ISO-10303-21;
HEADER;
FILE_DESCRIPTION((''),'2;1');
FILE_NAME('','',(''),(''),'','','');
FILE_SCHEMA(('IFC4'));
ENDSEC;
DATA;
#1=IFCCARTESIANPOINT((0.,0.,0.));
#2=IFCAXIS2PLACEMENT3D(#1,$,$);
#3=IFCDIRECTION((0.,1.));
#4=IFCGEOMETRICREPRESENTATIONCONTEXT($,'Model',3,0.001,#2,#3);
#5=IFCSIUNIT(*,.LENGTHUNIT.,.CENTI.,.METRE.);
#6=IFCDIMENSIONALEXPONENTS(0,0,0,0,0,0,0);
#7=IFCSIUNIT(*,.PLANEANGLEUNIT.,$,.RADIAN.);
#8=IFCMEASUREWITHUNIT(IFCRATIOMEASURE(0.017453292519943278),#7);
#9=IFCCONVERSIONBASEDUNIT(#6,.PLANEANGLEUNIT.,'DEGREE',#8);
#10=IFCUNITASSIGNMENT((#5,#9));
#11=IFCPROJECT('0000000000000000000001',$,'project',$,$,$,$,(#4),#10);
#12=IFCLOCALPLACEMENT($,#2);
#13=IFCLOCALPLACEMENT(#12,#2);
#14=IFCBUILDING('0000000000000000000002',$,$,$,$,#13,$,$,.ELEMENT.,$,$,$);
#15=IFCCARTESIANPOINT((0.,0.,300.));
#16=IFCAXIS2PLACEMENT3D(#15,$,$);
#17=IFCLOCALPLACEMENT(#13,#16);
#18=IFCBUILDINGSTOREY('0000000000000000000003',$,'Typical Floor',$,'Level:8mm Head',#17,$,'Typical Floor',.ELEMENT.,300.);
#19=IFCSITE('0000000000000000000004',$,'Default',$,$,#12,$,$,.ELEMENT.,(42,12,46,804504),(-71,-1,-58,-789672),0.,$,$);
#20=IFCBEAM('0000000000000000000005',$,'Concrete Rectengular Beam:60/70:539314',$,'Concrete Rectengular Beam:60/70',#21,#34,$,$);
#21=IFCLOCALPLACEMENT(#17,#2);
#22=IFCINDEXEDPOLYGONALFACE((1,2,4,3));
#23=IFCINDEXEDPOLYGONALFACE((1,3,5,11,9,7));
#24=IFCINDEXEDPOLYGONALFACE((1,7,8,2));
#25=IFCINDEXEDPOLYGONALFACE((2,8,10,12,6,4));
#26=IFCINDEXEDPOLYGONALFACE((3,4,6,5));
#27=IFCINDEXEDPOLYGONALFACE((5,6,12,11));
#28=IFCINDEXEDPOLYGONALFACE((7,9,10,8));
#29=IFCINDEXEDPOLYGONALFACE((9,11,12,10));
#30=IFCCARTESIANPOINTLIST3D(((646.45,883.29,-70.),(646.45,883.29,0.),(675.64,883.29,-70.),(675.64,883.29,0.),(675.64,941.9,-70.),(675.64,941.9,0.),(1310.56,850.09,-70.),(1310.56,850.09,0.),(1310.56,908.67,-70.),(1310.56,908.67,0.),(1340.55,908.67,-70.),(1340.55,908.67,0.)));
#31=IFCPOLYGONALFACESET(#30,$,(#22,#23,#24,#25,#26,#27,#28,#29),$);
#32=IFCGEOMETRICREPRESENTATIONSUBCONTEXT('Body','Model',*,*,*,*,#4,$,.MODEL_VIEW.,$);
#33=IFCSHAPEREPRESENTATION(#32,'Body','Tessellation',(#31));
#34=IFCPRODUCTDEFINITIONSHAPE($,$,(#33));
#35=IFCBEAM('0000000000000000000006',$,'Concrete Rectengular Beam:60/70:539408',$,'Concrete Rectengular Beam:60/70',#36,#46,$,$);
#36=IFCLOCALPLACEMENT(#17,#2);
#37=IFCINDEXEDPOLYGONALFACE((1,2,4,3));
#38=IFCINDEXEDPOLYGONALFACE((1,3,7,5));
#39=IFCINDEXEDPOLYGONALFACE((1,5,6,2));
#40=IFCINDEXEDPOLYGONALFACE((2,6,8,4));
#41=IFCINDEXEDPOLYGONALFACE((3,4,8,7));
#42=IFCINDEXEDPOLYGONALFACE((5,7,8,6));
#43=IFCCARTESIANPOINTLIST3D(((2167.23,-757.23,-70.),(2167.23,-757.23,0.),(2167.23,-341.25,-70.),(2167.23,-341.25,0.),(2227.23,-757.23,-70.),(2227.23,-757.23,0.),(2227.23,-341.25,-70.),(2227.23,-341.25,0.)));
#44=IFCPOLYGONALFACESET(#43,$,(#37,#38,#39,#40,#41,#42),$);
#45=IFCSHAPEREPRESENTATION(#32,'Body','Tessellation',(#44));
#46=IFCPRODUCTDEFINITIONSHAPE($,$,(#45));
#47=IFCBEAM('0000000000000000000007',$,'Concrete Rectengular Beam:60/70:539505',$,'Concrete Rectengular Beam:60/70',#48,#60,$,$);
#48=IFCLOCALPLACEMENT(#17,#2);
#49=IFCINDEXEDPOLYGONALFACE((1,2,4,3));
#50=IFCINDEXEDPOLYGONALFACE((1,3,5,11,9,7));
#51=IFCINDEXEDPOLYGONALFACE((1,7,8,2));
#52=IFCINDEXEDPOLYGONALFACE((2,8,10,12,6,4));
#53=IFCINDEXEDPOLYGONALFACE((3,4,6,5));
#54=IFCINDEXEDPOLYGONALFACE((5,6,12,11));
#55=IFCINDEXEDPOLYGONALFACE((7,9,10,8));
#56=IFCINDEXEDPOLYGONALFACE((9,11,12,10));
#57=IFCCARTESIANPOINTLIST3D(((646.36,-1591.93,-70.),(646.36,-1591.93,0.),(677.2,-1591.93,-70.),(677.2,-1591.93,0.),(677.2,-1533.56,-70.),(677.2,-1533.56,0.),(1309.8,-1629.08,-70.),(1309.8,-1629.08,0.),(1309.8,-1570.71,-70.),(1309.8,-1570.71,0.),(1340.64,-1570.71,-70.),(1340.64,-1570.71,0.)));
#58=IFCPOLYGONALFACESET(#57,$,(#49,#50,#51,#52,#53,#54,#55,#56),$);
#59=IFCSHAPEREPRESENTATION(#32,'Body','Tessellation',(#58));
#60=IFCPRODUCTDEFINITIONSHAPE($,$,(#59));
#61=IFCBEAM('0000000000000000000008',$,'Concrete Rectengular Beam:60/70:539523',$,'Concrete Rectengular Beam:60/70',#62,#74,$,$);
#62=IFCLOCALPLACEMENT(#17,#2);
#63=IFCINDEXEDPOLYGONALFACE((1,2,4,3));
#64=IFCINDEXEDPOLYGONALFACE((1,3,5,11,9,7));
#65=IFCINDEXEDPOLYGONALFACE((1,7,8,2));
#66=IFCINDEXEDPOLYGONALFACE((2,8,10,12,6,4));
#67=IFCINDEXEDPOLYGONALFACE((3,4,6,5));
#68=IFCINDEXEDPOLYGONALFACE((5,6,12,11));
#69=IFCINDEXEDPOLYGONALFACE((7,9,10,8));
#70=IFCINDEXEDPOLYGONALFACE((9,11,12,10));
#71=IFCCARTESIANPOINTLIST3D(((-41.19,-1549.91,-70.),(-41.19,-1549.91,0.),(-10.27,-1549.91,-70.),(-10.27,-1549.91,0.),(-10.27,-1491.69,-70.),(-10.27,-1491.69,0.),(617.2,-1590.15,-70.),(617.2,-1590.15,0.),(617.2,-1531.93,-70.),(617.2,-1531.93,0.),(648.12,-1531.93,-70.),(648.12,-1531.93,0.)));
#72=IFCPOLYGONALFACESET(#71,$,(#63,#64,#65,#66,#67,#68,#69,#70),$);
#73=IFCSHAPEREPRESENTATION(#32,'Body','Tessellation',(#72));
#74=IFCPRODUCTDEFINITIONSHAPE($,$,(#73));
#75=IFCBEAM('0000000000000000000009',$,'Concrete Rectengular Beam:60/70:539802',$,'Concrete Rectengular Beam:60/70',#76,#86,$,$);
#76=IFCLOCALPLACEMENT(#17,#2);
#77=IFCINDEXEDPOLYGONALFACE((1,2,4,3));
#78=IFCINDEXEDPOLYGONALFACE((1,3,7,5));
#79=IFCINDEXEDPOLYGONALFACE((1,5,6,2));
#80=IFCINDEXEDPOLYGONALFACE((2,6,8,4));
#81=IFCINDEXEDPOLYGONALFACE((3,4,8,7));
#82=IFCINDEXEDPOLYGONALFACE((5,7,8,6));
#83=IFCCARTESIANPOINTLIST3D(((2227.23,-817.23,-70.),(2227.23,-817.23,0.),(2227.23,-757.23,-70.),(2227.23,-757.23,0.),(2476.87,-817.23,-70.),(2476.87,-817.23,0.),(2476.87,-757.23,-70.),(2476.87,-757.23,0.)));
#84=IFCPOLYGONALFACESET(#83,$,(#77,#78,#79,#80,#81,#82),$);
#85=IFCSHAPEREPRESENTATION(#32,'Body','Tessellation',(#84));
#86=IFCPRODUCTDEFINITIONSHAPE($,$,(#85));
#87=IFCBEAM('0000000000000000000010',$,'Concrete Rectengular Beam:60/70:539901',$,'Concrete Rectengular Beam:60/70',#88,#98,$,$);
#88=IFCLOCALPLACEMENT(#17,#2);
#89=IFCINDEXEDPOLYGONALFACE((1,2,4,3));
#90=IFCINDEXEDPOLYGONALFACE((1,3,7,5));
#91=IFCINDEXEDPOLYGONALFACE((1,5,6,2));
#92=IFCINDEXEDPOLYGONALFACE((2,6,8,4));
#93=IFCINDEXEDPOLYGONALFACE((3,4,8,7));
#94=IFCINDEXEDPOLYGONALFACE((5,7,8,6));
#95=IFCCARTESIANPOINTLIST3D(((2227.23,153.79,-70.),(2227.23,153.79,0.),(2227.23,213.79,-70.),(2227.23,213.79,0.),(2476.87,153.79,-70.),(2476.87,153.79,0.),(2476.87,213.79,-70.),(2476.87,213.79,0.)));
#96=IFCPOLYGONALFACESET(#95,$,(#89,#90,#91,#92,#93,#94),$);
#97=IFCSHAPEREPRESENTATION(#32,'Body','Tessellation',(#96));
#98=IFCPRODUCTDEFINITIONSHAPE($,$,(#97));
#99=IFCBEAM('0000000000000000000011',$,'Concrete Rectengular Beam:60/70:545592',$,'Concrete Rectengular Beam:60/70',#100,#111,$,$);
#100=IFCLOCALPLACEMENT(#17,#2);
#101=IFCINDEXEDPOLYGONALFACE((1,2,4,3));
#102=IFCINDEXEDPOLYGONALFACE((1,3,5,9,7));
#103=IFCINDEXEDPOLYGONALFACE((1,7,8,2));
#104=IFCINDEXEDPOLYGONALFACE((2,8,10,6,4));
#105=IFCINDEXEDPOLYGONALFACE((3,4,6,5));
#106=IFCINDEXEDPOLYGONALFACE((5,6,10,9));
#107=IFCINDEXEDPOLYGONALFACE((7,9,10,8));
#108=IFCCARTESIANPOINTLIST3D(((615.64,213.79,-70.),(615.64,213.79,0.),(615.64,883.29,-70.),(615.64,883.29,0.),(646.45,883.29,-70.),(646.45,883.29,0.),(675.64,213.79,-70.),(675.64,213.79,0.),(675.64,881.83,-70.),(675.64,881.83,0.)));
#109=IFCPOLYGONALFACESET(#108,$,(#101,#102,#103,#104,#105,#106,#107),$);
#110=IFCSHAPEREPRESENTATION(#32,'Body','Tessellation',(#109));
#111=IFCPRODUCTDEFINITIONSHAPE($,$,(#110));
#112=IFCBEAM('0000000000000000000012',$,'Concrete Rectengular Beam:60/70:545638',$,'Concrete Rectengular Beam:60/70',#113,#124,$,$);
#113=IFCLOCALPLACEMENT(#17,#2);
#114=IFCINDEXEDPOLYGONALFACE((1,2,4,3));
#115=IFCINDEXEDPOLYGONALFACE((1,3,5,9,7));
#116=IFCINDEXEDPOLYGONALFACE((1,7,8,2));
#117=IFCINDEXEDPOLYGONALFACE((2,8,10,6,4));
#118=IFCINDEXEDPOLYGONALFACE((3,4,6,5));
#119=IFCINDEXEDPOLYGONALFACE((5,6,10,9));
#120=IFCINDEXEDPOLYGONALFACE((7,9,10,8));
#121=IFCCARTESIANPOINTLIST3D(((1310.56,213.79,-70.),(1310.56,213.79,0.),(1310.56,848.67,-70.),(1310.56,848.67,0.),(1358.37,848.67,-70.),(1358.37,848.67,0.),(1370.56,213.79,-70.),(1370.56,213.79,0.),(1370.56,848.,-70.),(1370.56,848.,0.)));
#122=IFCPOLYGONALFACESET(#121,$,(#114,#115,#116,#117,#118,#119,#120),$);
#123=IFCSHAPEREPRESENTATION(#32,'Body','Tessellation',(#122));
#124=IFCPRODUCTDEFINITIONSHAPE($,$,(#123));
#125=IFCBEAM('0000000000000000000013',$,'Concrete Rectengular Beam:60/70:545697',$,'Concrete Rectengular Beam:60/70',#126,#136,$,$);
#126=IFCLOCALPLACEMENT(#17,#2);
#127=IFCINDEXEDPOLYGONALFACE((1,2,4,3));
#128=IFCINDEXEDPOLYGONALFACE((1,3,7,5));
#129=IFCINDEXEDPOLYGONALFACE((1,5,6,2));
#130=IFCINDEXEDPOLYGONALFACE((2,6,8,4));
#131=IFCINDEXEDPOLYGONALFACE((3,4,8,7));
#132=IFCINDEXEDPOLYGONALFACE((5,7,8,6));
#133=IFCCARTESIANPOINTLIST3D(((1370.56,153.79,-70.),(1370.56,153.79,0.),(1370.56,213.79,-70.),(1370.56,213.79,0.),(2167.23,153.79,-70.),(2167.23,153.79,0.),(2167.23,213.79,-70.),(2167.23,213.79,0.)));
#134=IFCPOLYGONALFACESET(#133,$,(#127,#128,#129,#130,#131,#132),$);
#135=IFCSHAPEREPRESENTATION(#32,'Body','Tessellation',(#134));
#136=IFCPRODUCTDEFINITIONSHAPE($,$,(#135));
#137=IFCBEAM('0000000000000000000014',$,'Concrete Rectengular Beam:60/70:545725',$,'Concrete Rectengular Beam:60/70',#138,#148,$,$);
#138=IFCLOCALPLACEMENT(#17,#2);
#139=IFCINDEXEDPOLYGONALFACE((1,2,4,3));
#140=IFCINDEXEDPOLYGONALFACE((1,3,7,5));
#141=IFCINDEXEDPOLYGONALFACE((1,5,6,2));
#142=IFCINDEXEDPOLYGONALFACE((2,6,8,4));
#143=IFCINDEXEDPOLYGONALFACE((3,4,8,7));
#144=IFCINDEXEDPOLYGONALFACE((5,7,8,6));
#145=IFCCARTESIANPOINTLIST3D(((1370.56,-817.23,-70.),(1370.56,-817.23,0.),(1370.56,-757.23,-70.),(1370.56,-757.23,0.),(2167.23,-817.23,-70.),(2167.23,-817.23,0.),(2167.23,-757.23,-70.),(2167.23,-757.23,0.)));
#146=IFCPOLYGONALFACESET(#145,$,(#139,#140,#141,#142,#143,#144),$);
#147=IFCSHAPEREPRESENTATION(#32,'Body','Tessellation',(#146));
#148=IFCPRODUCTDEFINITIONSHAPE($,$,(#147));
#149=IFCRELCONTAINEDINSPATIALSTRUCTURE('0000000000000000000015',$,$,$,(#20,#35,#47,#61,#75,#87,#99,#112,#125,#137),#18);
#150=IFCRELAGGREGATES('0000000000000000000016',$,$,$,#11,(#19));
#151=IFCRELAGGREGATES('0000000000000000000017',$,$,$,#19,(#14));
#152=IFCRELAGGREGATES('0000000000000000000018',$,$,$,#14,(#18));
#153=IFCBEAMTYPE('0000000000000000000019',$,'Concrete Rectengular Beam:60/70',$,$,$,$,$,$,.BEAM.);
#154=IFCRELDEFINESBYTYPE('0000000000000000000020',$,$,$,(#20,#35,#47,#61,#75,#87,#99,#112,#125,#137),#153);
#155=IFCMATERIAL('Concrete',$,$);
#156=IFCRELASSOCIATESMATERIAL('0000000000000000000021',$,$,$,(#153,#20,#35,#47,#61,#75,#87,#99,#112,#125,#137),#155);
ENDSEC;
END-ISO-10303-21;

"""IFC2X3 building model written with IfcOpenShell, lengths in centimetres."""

from ifc_helpers import new_model, entity, si_unit, converted_unit, direction, frame, frame_2d, origin, origin_2d_with_axis, place, context, subcontext, project, spatial, polyline, rectangle, extrude, clip, halfspace, bounded_halfspace, material, type_object, element, save


model = new_model("IFC2X3")

# Units and contexts
model_context = context("Model", 3, precision=0.001, world=origin(), true_north=direction((0.0, 1.0)))
body_context = subcontext(model_context, "Body", "Model", "MODEL_VIEW")
ifc_project = project(units=[si_unit("LENGTHUNIT", "METRE", prefix="CENTI"), converted_unit("PLANEANGLEUNIT", "DEGREE", entity("IfcRatioMeasure", 0.017453292519943278), si_unit("PLANEANGLEUNIT", "RADIAN"), dimensions=[0, 0, 0, 0, 0, 0, 0])], contexts=[model_context])

# Site, building, storey
site_placement = place(None, origin())
site = spatial("IfcSite", under=ifc_project, at=site_placement, Name="Default", CompositionType="ELEMENT", RefLatitude=(42, 12, 46, 804504), RefLongitude=(-71, -1, -58, -789672), RefElevation=0.0)
building_placement = place(site_placement, origin())
building = spatial("IfcBuilding", under=site, at=building_placement, CompositionType="ELEMENT")
storey_placement = place(building_placement, frame((0.0, 0.0, 300.0)))
storey = spatial("IfcBuildingStorey", under=building, at=storey_placement, Name="Typical Floor", ObjectType="Level:8mm Head", LongName="Typical Floor", CompositionType="ELEMENT", Elevation=300.0)

# Beams
ifc_material = material(Name="Concrete")
beam_type = type_object("IfcBeamType", Name="Concrete Rectengular Beam:60/70", PredefinedType="BEAM", material=ifc_material)
beam_1_placement = place(storey_placement, frame((647.2, 913.29, 0.0), z_axis=(0.0, 0.0, 1.0), x_axis=(0.998753, -0.049923, 0.0)))
element("IfcBeam", 1, at=beam_1_placement, inside=storey, type_object=beam_type, material=ifc_material, Name="Concrete Rectengular Beam:60/70:539314", ObjectType="Concrete Rectengular Beam:60/70", context=body_context, shape_type="SweptSolid", body=[
    clip(clip(clip(clip(extrude(rectangle(XDim=70.0, YDim=60.0, at=frame_2d((0.0, 0.0), x_axis=(1.0, 0.0))), frame((0.75, 0.0, -35.0), z_axis=(1.0, 0.0, 0.0), x_axis=(0.0, 0.0, -1.0)), (0.0, 0.0, 1.0), 691.97), bounded_halfspace(frame((29.9, -28.54, 0.0), z_axis=(-0.998753, -0.049923, 0.0), x_axis=(0.0, 0.0, -1.0)), False, frame((0.75, 0.0, -35.0), z_axis=(1.0, 0.0, 0.0), x_axis=(0.0, 0.0, -1.0)), polyline([(35.0, -28.54), (-35.0, -28.54), (-35.0, 30.0), (35.0, 30.0), (35.0, -28.54)]))), bounded_halfspace(frame((-30.02, -31.54, 0.0), z_axis=(-0.049923, 0.998753, 0.0), x_axis=(0.0, 0.0, -1.0)), False, frame((0.75, 0.0, -35.0), z_axis=(1.0, 0.0, 0.0), x_axis=(0.0, 0.0, -1.0)), polyline([(-35.0, -28.54), (35.0, -28.54), (35.0, -30.0), (-35.0, -30.0), (-35.0, -28.54)]))), bounded_halfspace(frame((722.68, 31.5, 0.0), z_axis=(0.049923, -0.998753, 0.0), x_axis=(0.0, 0.0, -1.0)), False, frame((0.75, 0.0, -35.0), z_axis=(1.0, 0.0, 0.0), x_axis=(0.0, 0.0, -1.0)), polyline([(-35.0, 28.5), (35.0, 28.5), (35.0, 30.0), (-35.0, 30.0), (-35.0, 28.5)]))), bounded_halfspace(frame((662.76, 28.5, 0.0), z_axis=(0.998753, 0.049923, 0.0), x_axis=(0.0, 0.0, -1.0)), False, frame((0.75, 0.0, -35.0), z_axis=(1.0, 0.0, 0.0), x_axis=(0.0, 0.0, -1.0)), polyline([(35.0, 28.5), (-35.0, 28.5), (-35.0, -30.0), (-15.0, -30.0), (35.0, -30.0), (35.0, 28.5)]))),
])
beam_2_placement = place(storey_placement, frame((2197.23, -311.25, 0.0), z_axis=(0.0, 0.0, 1.0), x_axis=(0.0, -1.0, 0.0)))
element("IfcBeam", 2, at=beam_2_placement, inside=storey, type_object=beam_type, material=ifc_material, Name="Concrete Rectengular Beam:60/70:539408", ObjectType="Concrete Rectengular Beam:60/70", context=body_context, shape_type="SweptSolid", body=[
    extrude(rectangle(XDim=70.0, YDim=60.0, at=origin_2d_with_axis()), frame((30.0, 0.0, -35.0), z_axis=(1.0, 0.0, 0.0), x_axis=(0.0, 0.0, -1.0)), (0.0, 0.0, 1.0), 415.98),
])
beam_3_placement = place(storey_placement, frame((1339.8, -1600.71, 0.0), z_axis=(0.0, 0.0, 1.0), x_axis=(-0.998436, 0.055911, 0.0)))
element("IfcBeam", 3, at=beam_3_placement, inside=storey, type_object=beam_type, material=ifc_material, Name="Concrete Rectengular Beam:60/70:539505", ObjectType="Concrete Rectengular Beam:60/70", context=body_context, shape_type="SweptSolid", body=[
    clip(clip(clip(clip(extrude(rectangle(XDim=70.0, YDim=60.0, at=frame_2d((0.0, 0.0), x_axis=(1.0, 0.0))), frame((0.84, 0.0, -35.0), z_axis=(1.0, 0.0, 0.0), x_axis=(0.0, 0.0, -1.0)), (0.0, 0.0, 1.0), 692.01), bounded_halfspace(frame((662.06, 28.28, 0.0), z_axis=(0.998436, 0.055911, 0.0), x_axis=(0.0, 0.0, -1.0)), False, frame((0.84, 0.0, -35.0), z_axis=(1.0, 0.0, 0.0), x_axis=(0.0, 0.0, -1.0)), polyline([(35.0, 28.28), (-35.0, 28.28), (-35.0, -30.0), (-10.0, -30.0), (35.0, -30.0), (35.0, 28.28)]))), bounded_halfspace(frame((721.96, 31.63, 0.0), z_axis=(0.055911, -0.998436, 0.0), x_axis=(0.0, 0.0, -1.0)), False, frame((0.84, 0.0, -35.0), z_axis=(1.0, 0.0, 0.0), x_axis=(0.0, 0.0, -1.0)), polyline([(-35.0, 28.28), (35.0, 28.28), (35.0, 30.0), (-35.0, 30.0), (-35.0, 28.28)]))), bounded_halfspace(frame((-28.28, -31.63, 0.0), z_axis=(-0.055911, 0.998436, 0.0), x_axis=(0.0, 0.0, -1.0)), False, frame((0.84, 0.0, -35.0), z_axis=(1.0, 0.0, 0.0), x_axis=(0.0, 0.0, -1.0)), polyline([(-35.0, -28.28), (35.0, -28.28), (35.0, -30.0), (-35.0, -30.0), (-35.0, -28.28)]))), bounded_halfspace(frame((31.63, -28.28, 0.0), z_axis=(-0.998436, -0.055911, 0.0), x_axis=(0.0, 0.0, -1.0)), False, frame((0.84, 0.0, -35.0), z_axis=(1.0, 0.0, 0.0), x_axis=(0.0, 0.0, -1.0)), polyline([(35.0, -28.28), (-35.0, -28.28), (-35.0, 30.0), (35.0, 30.0), (35.0, -28.28)]))),
])
beam_4_placement = place(storey_placement, frame((647.2, -1561.93, 0.0), z_axis=(0.0, 0.0, 1.0), x_axis=(-0.998138, 0.061004, 0.0)))
element("IfcBeam", 4, at=beam_4_placement, inside=storey, type_object=beam_type, material=ifc_material, Name="Concrete Rectengular Beam:60/70:539523", ObjectType="Concrete Rectengular Beam:60/70", context=body_context, shape_type="SweptSolid", body=[
    clip(clip(clip(clip(extrude(rectangle(XDim=70.0, YDim=60.0, at=frame_2d((0.0, 0.0), x_axis=(1.0, 0.0))), frame((0.92, 0.0, -35.0), z_axis=(1.0, 0.0, 0.0), x_axis=(0.0, 0.0, -1.0)), (0.0, 0.0, 1.0), 686.93), bounded_halfspace(frame((656.98, 28.11, 0.0), z_axis=(0.998138, 0.061004, 0.0), x_axis=(0.0, 0.0, -1.0)), False, frame((0.92, 0.0, -35.0), z_axis=(1.0, 0.0, 0.0), x_axis=(0.0, 0.0, -1.0)), polyline([(35.0, 28.11), (-35.0, 28.11), (-35.0, -30.0), (-15.0, -30.0), (35.0, -30.0), (35.0, 28.11)]))), bounded_halfspace(frame((716.87, 31.77, 0.0), z_axis=(0.061004, -0.998138, 0.0), x_axis=(0.0, 0.0, -1.0)), False, frame((0.92, 0.0, -35.0), z_axis=(1.0, 0.0, 0.0), x_axis=(0.0, 0.0, -1.0)), polyline([(-35.0, 28.11), (35.0, 28.11), (35.0, 30.0), (-35.0, 30.0), (-35.0, 28.11)]))), bounded_halfspace(frame((-28.11, -31.77, 0.0), z_axis=(-0.061004, 0.998138, 0.0), x_axis=(0.0, 0.0, -1.0)), False, frame((0.92, 0.0, -35.0), z_axis=(1.0, 0.0, 0.0), x_axis=(0.0, 0.0, -1.0)), polyline([(-35.0, -28.11), (35.0, -28.11), (35.0, -30.0), (-35.0, -30.0), (-35.0, -28.11)]))), bounded_halfspace(frame((31.77, -28.11, 0.0), z_axis=(-0.998138, -0.061004, 0.0), x_axis=(0.0, 0.0, -1.0)), False, frame((0.92, 0.0, -35.0), z_axis=(1.0, 0.0, 0.0), x_axis=(0.0, 0.0, -1.0)), polyline([(35.0, -28.11), (-35.0, -28.11), (-35.0, 30.0), (35.0, 30.0), (35.0, -28.11)]))),
])
beam_5_placement = place(storey_placement, frame((2197.23, -787.23, 0.0)))
element("IfcBeam", 5, at=beam_5_placement, inside=storey, type_object=beam_type, material=ifc_material, Name="Concrete Rectengular Beam:60/70:539802", ObjectType="Concrete Rectengular Beam:60/70", context=body_context, shape_type="SweptSolid", body=[
    extrude(rectangle(XDim=70.0, YDim=60.0, at=frame_2d((0.0, 0.0), x_axis=(1.0, 0.0))), frame((30.0, 0.0, -35.0), z_axis=(1.0, 0.0, 0.0), x_axis=(0.0, 0.0, -1.0)), (0.0, 0.0, 1.0), 249.64),
])
beam_6_placement = place(storey_placement, frame((2197.23, 183.79, 0.0)))
element("IfcBeam", 6, at=beam_6_placement, inside=storey, type_object=beam_type, material=ifc_material, Name="Concrete Rectengular Beam:60/70:539901", ObjectType="Concrete Rectengular Beam:60/70", context=body_context, shape_type="SweptSolid", body=[
    extrude(rectangle(XDim=70.0, YDim=60.0, at=frame_2d((0.0, 0.0), x_axis=(1.0, 0.0))), frame((30.0, 0.0, -35.0), z_axis=(1.0, 0.0, 0.0), x_axis=(0.0, 0.0, -1.0)), (0.0, 0.0, 1.0), 249.64),
])
beam_7_placement = place(storey_placement, frame((645.64, 913.29, 0.0), z_axis=(0.0, 0.0, 1.0), x_axis=(0.0, -1.0, 0.0)))
element("IfcBeam", 7, at=beam_7_placement, inside=storey, type_object=beam_type, material=ifc_material, Name="Concrete Rectengular Beam:60/70:545592", ObjectType="Concrete Rectengular Beam:60/70", context=body_context, shape_type="SweptSolid", body=[
    clip(extrude(rectangle(XDim=70.0, YDim=60.0, at=frame_2d((0.0, 0.0), x_axis=(1.0, 0.0))), frame((30.0, 0.0, -35.0), z_axis=(1.0, 0.0, 0.0), x_axis=(0.0, 0.0, -1.0)), (0.0, 0.0, 1.0), 669.5), halfspace(frame((62.99, 660.72, 0.0), z_axis=(-0.998753, 0.049923, 0.0), x_axis=(-0.049923, -0.998753, 0.0)), False)),
])
beam_8_placement = place(storey_placement, frame((1340.56, 878.67, 0.0), z_axis=(0.0, 0.0, 1.0), x_axis=(0.0, -1.0, 0.0)))
element("IfcBeam", 8, at=beam_8_placement, inside=storey, type_object=beam_type, material=ifc_material, Name="Concrete Rectengular Beam:60/70:545638", ObjectType="Concrete Rectengular Beam:60/70", context=body_context, shape_type="SweptSolid", body=[
    clip(extrude(rectangle(XDim=70.0, YDim=60.0, at=frame_2d((0.0, 0.0), x_axis=(1.0, 0.0))), frame((30.0, 0.0, -35.0), z_axis=(1.0, 0.0, 0.0), x_axis=(0.0, 0.0, -1.0)), (0.0, 0.0, 1.0), 634.88), halfspace(frame((74.03, 822.34, 0.0), z_axis=(-0.998506, 0.054646, 0.0), x_axis=(-0.054646, -0.998506, 0.0)), False)),
])
beam_9_placement = place(storey_placement, frame((2197.23, 183.79, 0.0), z_axis=(0.0, 0.0, 1.0), x_axis=(-1.0, 0.0, 0.0)))
element("IfcBeam", 9, at=beam_9_placement, inside=storey, type_object=beam_type, material=ifc_material, Name="Concrete Rectengular Beam:60/70:545697", ObjectType="Concrete Rectengular Beam:60/70", context=body_context, shape_type="SweptSolid", body=[
    extrude(rectangle(XDim=70.0, YDim=60.0, at=frame_2d((0.0, 0.0), x_axis=(1.0, 0.0))), frame((30.0, 0.0, -35.0), z_axis=(1.0, 0.0, 0.0), x_axis=(0.0, 0.0, -1.0)), (0.0, 0.0, 1.0), 796.67),
])
beam_10_placement = place(storey_placement, frame((2197.23, -787.23, 0.0), z_axis=(0.0, 0.0, 1.0), x_axis=(-1.0, 0.0, 0.0)))
element("IfcBeam", 10, at=beam_10_placement, inside=storey, type_object=beam_type, material=ifc_material, Name="Concrete Rectengular Beam:60/70:545725", ObjectType="Concrete Rectengular Beam:60/70", context=body_context, shape_type="SweptSolid", body=[
    extrude(rectangle(XDim=70.0, YDim=60.0, at=frame_2d((0.0, 0.0), x_axis=(1.0, 0.0))), frame((30.0, 0.0, -35.0), z_axis=(1.0, 0.0, 0.0), x_axis=(0.0, 0.0, -1.0)), (0.0, 0.0, 1.0), 796.67),
])

save(model, "model.ifc")
